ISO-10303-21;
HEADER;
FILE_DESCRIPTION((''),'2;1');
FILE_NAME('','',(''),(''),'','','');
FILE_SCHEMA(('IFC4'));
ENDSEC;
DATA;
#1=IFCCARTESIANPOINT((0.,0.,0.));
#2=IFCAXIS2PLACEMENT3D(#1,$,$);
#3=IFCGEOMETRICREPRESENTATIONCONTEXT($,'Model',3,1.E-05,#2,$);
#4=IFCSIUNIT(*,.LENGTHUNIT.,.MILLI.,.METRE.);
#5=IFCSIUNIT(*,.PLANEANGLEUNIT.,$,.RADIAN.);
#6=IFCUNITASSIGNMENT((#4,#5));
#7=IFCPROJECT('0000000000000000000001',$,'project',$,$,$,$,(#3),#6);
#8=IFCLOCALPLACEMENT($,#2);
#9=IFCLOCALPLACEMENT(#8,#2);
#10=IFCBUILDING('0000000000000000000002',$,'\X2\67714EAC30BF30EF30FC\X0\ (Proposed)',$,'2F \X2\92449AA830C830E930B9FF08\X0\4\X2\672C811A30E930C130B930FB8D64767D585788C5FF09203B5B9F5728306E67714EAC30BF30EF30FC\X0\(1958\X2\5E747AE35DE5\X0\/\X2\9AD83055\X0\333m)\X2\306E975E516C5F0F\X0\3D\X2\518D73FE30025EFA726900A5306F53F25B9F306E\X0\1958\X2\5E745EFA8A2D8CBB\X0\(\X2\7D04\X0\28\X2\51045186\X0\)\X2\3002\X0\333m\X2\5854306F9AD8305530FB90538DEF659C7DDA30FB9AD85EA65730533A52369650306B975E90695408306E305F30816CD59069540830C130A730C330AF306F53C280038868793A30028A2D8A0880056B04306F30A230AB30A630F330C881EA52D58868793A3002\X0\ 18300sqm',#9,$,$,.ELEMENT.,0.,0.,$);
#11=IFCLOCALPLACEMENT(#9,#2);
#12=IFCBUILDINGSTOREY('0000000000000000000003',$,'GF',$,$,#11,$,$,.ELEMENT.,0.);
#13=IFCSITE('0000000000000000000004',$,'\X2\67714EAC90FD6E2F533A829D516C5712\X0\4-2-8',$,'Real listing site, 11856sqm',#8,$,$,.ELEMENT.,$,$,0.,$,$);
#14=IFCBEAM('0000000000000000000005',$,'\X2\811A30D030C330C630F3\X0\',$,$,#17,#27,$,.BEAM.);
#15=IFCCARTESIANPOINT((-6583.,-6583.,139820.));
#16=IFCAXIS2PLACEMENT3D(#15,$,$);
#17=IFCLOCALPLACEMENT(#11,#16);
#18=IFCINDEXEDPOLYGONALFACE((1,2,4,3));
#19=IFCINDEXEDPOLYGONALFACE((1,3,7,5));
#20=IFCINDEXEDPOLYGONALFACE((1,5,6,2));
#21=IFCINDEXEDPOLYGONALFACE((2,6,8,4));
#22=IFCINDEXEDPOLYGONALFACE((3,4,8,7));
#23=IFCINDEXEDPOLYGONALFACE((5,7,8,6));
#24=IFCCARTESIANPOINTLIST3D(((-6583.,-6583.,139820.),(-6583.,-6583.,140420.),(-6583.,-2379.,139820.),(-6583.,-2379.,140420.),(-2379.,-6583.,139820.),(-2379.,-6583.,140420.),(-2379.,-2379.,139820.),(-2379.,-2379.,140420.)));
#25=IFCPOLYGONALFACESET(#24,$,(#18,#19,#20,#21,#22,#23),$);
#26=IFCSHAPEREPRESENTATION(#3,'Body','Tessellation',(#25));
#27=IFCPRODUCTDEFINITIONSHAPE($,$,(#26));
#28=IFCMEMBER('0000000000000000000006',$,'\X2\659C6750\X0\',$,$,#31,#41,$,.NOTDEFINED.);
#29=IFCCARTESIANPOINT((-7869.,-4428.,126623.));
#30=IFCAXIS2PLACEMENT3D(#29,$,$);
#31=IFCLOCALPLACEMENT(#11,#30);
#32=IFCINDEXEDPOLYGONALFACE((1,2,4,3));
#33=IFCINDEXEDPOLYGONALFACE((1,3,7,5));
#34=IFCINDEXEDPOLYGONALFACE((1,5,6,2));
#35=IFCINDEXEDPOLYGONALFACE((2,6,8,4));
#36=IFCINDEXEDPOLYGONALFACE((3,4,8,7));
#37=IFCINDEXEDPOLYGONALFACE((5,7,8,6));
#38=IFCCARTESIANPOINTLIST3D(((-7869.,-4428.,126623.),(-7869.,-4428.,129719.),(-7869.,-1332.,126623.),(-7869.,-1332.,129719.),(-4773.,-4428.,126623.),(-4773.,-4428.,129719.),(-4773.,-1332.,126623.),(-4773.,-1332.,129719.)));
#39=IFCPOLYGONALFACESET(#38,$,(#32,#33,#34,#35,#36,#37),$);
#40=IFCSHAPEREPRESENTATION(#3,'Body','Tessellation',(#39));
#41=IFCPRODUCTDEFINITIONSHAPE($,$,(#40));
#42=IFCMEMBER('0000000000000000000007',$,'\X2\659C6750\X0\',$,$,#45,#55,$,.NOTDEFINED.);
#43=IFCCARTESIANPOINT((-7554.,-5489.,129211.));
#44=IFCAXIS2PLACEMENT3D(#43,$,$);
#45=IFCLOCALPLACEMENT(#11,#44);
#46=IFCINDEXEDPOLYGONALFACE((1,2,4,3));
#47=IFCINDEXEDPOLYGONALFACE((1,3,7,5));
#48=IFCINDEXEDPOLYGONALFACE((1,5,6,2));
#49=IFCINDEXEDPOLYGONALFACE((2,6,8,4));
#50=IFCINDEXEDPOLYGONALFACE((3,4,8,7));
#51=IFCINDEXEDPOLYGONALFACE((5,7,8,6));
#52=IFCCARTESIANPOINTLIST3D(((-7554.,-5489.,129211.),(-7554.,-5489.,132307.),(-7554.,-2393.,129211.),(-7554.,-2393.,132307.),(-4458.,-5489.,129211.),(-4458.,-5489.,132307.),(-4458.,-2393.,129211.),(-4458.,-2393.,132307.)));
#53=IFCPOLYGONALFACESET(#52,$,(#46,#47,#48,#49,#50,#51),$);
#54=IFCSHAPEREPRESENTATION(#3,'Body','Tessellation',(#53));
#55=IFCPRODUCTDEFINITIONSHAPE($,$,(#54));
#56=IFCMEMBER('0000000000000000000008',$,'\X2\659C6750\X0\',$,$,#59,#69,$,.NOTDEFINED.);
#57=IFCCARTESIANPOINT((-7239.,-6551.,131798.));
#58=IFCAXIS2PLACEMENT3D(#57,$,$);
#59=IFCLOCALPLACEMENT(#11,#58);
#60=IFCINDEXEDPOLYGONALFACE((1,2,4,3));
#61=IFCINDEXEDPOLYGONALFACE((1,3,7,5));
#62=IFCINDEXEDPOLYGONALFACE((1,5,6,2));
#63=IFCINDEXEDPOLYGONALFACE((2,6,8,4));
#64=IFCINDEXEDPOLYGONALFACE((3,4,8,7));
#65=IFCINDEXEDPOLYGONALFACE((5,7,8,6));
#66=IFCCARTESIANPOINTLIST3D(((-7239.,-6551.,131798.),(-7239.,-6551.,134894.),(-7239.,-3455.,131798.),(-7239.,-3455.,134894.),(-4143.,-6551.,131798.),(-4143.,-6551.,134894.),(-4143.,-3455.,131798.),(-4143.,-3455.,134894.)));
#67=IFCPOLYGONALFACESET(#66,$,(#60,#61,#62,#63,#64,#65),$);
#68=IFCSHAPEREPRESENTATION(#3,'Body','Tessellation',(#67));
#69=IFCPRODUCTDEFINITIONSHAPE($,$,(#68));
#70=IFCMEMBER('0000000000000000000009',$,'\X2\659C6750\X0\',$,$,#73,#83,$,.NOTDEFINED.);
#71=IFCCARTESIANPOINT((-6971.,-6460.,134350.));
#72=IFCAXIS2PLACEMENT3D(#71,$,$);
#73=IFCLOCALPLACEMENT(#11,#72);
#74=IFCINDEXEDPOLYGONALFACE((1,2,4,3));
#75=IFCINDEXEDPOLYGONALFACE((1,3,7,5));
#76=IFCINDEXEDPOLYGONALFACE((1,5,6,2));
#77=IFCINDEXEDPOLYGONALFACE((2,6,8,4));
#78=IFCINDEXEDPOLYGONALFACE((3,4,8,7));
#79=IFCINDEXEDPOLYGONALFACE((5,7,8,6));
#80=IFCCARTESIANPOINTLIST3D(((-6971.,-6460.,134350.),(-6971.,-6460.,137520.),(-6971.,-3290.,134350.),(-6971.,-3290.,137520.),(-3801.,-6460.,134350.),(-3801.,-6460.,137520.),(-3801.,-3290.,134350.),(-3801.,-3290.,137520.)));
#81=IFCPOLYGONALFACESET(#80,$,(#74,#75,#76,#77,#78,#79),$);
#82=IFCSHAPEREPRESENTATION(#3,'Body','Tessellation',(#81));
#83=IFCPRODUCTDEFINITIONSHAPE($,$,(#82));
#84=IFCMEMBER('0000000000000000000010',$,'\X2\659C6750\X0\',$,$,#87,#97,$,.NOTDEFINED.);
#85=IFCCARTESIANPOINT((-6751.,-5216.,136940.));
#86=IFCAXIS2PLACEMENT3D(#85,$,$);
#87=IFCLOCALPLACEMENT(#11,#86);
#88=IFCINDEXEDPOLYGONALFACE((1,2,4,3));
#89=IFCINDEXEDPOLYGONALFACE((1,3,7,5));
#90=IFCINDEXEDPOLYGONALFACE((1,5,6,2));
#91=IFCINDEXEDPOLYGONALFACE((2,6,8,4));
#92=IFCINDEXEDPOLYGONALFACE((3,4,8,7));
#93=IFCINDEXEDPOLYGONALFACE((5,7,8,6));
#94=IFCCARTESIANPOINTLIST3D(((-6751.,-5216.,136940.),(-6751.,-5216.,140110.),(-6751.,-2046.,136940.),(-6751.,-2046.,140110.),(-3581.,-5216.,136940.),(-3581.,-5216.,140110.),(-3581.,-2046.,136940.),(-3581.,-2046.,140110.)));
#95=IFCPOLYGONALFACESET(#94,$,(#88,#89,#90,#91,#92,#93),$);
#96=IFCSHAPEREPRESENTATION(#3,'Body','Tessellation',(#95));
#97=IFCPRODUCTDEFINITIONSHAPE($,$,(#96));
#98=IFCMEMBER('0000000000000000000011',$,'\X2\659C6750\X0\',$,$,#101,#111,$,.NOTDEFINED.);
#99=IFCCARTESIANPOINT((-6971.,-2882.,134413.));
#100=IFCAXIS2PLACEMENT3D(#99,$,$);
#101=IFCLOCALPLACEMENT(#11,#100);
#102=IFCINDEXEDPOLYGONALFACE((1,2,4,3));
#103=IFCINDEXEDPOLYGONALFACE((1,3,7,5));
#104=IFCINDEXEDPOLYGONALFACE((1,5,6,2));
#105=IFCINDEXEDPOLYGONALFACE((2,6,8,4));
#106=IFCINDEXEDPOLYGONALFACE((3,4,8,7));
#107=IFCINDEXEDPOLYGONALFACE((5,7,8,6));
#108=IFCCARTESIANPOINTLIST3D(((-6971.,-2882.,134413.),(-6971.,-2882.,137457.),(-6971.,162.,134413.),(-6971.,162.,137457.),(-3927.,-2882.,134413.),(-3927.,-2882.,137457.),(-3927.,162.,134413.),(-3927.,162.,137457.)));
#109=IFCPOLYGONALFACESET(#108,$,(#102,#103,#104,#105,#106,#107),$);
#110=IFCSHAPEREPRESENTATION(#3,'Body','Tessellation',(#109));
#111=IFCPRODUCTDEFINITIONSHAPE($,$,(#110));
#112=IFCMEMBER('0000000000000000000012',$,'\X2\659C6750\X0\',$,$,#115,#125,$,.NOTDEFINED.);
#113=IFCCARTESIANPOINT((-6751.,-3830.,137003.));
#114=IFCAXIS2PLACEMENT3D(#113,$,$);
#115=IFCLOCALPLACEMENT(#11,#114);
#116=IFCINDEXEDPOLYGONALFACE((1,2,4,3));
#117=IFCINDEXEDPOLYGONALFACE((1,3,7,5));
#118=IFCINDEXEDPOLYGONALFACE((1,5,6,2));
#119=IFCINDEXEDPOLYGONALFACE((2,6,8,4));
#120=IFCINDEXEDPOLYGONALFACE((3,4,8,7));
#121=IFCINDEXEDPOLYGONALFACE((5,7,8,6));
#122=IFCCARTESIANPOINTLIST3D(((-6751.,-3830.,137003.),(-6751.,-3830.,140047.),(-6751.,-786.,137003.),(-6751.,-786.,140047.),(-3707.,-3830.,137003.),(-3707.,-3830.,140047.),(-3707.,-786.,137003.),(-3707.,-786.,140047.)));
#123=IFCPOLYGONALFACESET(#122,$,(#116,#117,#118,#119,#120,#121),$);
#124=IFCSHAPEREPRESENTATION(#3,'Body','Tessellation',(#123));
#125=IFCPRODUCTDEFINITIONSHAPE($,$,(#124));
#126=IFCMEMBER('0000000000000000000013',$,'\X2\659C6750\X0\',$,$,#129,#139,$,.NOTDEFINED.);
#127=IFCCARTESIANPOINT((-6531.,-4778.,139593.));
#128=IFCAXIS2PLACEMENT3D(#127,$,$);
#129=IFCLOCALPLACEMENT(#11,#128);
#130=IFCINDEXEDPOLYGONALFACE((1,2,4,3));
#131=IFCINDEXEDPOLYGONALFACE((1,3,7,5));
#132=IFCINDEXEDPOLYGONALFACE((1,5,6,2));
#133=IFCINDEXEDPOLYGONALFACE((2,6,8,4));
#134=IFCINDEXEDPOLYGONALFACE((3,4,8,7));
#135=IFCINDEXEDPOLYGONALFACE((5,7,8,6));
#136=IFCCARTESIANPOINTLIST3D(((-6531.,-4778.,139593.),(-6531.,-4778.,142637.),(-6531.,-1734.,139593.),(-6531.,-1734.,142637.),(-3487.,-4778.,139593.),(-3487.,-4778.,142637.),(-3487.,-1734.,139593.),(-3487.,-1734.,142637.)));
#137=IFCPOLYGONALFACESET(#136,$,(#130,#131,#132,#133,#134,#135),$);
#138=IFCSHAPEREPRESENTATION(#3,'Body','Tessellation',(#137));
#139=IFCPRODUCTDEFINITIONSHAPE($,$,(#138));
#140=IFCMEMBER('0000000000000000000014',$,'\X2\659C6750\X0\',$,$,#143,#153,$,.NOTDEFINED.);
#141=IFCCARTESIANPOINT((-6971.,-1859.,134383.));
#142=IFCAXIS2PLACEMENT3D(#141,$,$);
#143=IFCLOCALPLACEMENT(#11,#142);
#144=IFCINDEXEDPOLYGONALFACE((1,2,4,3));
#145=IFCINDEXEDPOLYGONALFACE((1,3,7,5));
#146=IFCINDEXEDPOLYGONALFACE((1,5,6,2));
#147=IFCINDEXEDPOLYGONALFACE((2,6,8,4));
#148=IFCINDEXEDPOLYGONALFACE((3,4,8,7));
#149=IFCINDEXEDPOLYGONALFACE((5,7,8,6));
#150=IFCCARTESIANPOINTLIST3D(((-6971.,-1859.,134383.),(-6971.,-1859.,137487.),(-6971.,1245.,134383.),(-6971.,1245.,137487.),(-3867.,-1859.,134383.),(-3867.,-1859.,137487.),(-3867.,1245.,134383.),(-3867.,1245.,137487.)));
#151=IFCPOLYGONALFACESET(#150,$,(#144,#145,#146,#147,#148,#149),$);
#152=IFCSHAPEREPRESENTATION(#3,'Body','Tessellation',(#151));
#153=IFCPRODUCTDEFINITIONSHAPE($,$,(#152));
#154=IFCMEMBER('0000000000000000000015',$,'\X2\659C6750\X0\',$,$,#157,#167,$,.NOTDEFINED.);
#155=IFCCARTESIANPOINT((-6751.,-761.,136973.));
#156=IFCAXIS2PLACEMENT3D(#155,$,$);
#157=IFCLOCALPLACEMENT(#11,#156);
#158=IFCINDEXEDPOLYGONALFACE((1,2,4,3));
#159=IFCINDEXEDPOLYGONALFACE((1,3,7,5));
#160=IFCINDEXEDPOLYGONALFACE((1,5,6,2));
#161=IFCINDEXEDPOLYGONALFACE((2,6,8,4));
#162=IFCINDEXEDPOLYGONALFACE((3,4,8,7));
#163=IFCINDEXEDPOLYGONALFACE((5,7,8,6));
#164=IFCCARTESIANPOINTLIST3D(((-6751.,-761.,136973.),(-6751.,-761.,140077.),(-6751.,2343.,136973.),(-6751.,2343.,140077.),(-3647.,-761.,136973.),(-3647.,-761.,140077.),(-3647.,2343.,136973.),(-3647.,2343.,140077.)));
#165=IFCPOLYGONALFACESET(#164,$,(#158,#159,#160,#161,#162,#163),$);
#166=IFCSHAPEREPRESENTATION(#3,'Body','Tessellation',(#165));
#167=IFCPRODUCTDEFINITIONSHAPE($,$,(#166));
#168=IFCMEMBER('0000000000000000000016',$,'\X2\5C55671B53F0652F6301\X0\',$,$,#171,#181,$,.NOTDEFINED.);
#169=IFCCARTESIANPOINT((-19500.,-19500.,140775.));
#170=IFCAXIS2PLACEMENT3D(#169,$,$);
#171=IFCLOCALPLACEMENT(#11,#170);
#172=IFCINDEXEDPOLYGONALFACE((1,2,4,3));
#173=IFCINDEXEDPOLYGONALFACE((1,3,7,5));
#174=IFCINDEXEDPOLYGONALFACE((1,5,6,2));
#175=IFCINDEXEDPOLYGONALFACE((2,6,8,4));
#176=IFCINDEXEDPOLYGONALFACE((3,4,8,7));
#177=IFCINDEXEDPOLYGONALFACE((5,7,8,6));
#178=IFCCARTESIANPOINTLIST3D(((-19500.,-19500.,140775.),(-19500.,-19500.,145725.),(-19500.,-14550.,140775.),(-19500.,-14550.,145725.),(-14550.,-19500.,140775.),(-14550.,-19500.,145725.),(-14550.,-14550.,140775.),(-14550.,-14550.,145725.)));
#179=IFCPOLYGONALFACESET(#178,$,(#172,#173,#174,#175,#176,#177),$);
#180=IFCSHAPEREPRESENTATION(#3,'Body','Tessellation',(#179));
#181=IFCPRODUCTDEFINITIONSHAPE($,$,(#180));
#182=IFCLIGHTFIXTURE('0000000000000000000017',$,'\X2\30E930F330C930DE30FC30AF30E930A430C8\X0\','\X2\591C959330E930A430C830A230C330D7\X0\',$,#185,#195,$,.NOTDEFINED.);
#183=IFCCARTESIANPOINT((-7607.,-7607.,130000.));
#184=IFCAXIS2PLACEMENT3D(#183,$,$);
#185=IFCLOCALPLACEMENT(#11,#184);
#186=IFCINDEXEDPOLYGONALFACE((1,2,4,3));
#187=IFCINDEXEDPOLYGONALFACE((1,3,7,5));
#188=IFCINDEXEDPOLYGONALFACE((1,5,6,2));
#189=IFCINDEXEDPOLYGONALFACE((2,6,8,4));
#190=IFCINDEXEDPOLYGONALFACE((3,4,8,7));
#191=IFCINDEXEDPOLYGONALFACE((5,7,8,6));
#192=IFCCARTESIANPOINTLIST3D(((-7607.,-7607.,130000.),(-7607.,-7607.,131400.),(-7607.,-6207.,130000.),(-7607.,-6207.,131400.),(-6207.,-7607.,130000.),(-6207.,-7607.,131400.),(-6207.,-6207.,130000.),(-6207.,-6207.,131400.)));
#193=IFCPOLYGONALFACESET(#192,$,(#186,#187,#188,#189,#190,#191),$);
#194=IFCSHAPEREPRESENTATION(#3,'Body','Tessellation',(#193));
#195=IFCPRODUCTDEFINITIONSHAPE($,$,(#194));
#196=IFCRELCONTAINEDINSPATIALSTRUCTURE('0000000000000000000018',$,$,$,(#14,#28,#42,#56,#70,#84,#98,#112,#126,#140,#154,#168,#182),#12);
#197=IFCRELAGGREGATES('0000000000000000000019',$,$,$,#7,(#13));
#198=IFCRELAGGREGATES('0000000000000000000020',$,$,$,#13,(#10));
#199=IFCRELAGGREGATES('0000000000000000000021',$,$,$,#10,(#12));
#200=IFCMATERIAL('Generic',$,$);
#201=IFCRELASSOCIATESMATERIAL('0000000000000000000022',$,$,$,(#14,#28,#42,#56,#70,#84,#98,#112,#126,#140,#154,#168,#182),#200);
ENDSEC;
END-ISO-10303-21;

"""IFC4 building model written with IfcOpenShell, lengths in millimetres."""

from ifc_helpers import new_model, si_unit, frame, frame_2d, origin, place, context, project, spatial, rectangle, extrude, material, element, save


model = new_model("IFC4")

# Units and contexts
model_context = context("Model", 3, precision=1e-05, world=origin())
ifc_project = project(units=[si_unit("LENGTHUNIT", "METRE", prefix="MILLI"), si_unit("PLANEANGLEUNIT", "RADIAN")], contexts=[model_context])

# Site, building, storey
site_placement = place(None, origin())
site = spatial("IfcSite", under=ifc_project, at=site_placement, Name="東京都港区芝公園4-2-8", ObjectType="Real listing site, 11856sqm", CompositionType="ELEMENT", RefElevation=0.0)
building_placement = place(site_placement, origin())
building = spatial("IfcBuilding", under=site, at=building_placement, Name="東京タワー (Proposed)", ObjectType="2F 鉄骨トラス（4本脚ラチス・赤白塗装）※実在の東京タワー(1958年竣工/高さ333m)の非公式3D再現。建物¥は史実の1958年建設費(約28億円)。333m塔は高さ・道路斜線・高度地区制限に非適合のため法適合チェックは参考表示。設計者欄はアカウント自動表示。 18300sqm", CompositionType="ELEMENT", ElevationOfRefHeight=0.0, ElevationOfTerrain=0.0)
storey_placement = place(building_placement, origin())
storey = spatial("IfcBuildingStorey", under=building, at=storey_placement, Name="GF", CompositionType="ELEMENT", Elevation=0.0)

# Shared definitions
ifc_material = material(Name="Generic")

# Beam
beam_1_placement = place(storey_placement, frame((-6583.0, -6583.0, 139820.0)))
element("IfcBeam", 1, at=beam_1_placement, inside=storey, material=ifc_material, Name="脚バッテン", PredefinedType="BEAM", context=model_context, shape_type="SweptSolid", body=[
    extrude(rectangle(XDim=4204.0, YDim=4204.0, at=frame_2d((2102.0, 2102.0))), frame((-6583.0, -6583.0, 139820.0)), (0.0, 0.0, 1.0), 600.0),
])

# Members
member_1_placement = place(storey_placement, frame((-7869.0, -4428.0, 126623.0)))
element("IfcMember", 2, at=member_1_placement, inside=storey, material=ifc_material, Name="斜材", PredefinedType="NOTDEFINED", context=model_context, shape_type="SweptSolid", body=[
    extrude(rectangle(XDim=3096.0, YDim=3096.0, at=frame_2d((1548.0, 1548.0))), frame((-7869.0, -4428.0, 126623.0)), (0.0, 0.0, 1.0), 3096.0),
])
member_2_placement = place(storey_placement, frame((-7554.0, -5489.0, 129211.0)))
element("IfcMember", 3, at=member_2_placement, inside=storey, material=ifc_material, Name="斜材", PredefinedType="NOTDEFINED", context=model_context, shape_type="SweptSolid", body=[
    extrude(rectangle(XDim=3096.0, YDim=3096.0, at=frame_2d((1548.0, 1548.0))), frame((-7554.0, -5489.0, 129211.0)), (0.0, 0.0, 1.0), 3096.0),
])
member_3_placement = place(storey_placement, frame((-7239.0, -6551.0, 131798.0)))
element("IfcMember", 4, at=member_3_placement, inside=storey, material=ifc_material, Name="斜材", PredefinedType="NOTDEFINED", context=model_context, shape_type="SweptSolid", body=[
    extrude(rectangle(XDim=3096.0, YDim=3096.0, at=frame_2d((1548.0, 1548.0))), frame((-7239.0, -6551.0, 131798.0)), (0.0, 0.0, 1.0), 3096.0),
])
member_4_placement = place(storey_placement, frame((-6971.0, -6460.0, 134350.0)))
element("IfcMember", 5, at=member_4_placement, inside=storey, material=ifc_material, Name="斜材", PredefinedType="NOTDEFINED", context=model_context, shape_type="SweptSolid", body=[
    extrude(rectangle(XDim=3170.0, YDim=3170.0, at=frame_2d((1585.0, 1585.0))), frame((-6971.0, -6460.0, 134350.0)), (0.0, 0.0, 1.0), 3170.0),
])
member_5_placement = place(storey_placement, frame((-6751.0, -5216.0, 136940.0)))
element("IfcMember", 6, at=member_5_placement, inside=storey, material=ifc_material, Name="斜材", PredefinedType="NOTDEFINED", context=model_context, shape_type="SweptSolid", body=[
    extrude(rectangle(XDim=3170.0, YDim=3170.0, at=frame_2d((1585.0, 1585.0))), frame((-6751.0, -5216.0, 136940.0)), (0.0, 0.0, 1.0), 3170.0),
])
member_6_placement = place(storey_placement, frame((-6971.0, -2882.0, 134413.0)))
element("IfcMember", 7, at=member_6_placement, inside=storey, material=ifc_material, Name="斜材", PredefinedType="NOTDEFINED", context=model_context, shape_type="SweptSolid", body=[
    extrude(rectangle(XDim=3044.0, YDim=3044.0, at=frame_2d((1522.0, 1522.0))), frame((-6971.0, -2882.0, 134413.0)), (0.0, 0.0, 1.0), 3044.0),
])
member_7_placement = place(storey_placement, frame((-6751.0, -3830.0, 137003.0)))
element("IfcMember", 8, at=member_7_placement, inside=storey, material=ifc_material, Name="斜材", PredefinedType="NOTDEFINED", context=model_context, shape_type="SweptSolid", body=[
    extrude(rectangle(XDim=3044.0, YDim=3044.0, at=frame_2d((1522.0, 1522.0))), frame((-6751.0, -3830.0, 137003.0)), (0.0, 0.0, 1.0), 3044.0),
])
member_8_placement = place(storey_placement, frame((-6531.0, -4778.0, 139593.0)))
element("IfcMember", 9, at=member_8_placement, inside=storey, material=ifc_material, Name="斜材", PredefinedType="NOTDEFINED", context=model_context, shape_type="SweptSolid", body=[
    extrude(rectangle(XDim=3044.0, YDim=3044.0, at=frame_2d((1522.0, 1522.0))), frame((-6531.0, -4778.0, 139593.0)), (0.0, 0.0, 1.0), 3044.0),
])
member_9_placement = place(storey_placement, frame((-6971.0, -1859.0, 134383.0)))
element("IfcMember", 10, at=member_9_placement, inside=storey, material=ifc_material, Name="斜材", PredefinedType="NOTDEFINED", context=model_context, shape_type="SweptSolid", body=[
    extrude(rectangle(XDim=3104.0, YDim=3104.0, at=frame_2d((1552.0, 1552.0))), frame((-6971.0, -1859.0, 134383.0)), (0.0, 0.0, 1.0), 3104.0),
])
member_10_placement = place(storey_placement, frame((-6751.0, -761.0, 136973.0)))
element("IfcMember", 11, at=member_10_placement, inside=storey, material=ifc_material, Name="斜材", PredefinedType="NOTDEFINED", context=model_context, shape_type="SweptSolid", body=[
    extrude(rectangle(XDim=3104.0, YDim=3104.0, at=frame_2d((1552.0, 1552.0))), frame((-6751.0, -761.0, 136973.0)), (0.0, 0.0, 1.0), 3104.0),
])
member_11_placement = place(storey_placement, frame((-19500.0, -19500.0, 140775.0)))
element("IfcMember", 12, at=member_11_placement, inside=storey, material=ifc_material, Name="展望台支持", PredefinedType="NOTDEFINED", context=model_context, shape_type="SweptSolid", body=[
    extrude(rectangle(XDim=4950.0, YDim=4950.0, at=frame_2d((2475.0, 2475.0))), frame((-19500.0, -19500.0, 140775.0)), (0.0, 0.0, 1.0), 4950.0),
])

# Light fixture
light_fixture_placement = place(storey_placement, frame((-7607.0, -7607.0, 130000.0)))
element("IfcLightFixture", 13, at=light_fixture_placement, inside=storey, material=ifc_material, Name="ランドマークライト", Description="夜間ライトアップ", PredefinedType="NOTDEFINED", context=model_context, shape_type="SweptSolid", body=[
    extrude(rectangle(XDim=1400.0, YDim=1400.0, at=frame_2d((700.0, 700.0))), frame((-7607.0, -7607.0, 130000.0)), (0.0, 0.0, 1.0), 1400.0),
])

save(model, "model.ifc")
